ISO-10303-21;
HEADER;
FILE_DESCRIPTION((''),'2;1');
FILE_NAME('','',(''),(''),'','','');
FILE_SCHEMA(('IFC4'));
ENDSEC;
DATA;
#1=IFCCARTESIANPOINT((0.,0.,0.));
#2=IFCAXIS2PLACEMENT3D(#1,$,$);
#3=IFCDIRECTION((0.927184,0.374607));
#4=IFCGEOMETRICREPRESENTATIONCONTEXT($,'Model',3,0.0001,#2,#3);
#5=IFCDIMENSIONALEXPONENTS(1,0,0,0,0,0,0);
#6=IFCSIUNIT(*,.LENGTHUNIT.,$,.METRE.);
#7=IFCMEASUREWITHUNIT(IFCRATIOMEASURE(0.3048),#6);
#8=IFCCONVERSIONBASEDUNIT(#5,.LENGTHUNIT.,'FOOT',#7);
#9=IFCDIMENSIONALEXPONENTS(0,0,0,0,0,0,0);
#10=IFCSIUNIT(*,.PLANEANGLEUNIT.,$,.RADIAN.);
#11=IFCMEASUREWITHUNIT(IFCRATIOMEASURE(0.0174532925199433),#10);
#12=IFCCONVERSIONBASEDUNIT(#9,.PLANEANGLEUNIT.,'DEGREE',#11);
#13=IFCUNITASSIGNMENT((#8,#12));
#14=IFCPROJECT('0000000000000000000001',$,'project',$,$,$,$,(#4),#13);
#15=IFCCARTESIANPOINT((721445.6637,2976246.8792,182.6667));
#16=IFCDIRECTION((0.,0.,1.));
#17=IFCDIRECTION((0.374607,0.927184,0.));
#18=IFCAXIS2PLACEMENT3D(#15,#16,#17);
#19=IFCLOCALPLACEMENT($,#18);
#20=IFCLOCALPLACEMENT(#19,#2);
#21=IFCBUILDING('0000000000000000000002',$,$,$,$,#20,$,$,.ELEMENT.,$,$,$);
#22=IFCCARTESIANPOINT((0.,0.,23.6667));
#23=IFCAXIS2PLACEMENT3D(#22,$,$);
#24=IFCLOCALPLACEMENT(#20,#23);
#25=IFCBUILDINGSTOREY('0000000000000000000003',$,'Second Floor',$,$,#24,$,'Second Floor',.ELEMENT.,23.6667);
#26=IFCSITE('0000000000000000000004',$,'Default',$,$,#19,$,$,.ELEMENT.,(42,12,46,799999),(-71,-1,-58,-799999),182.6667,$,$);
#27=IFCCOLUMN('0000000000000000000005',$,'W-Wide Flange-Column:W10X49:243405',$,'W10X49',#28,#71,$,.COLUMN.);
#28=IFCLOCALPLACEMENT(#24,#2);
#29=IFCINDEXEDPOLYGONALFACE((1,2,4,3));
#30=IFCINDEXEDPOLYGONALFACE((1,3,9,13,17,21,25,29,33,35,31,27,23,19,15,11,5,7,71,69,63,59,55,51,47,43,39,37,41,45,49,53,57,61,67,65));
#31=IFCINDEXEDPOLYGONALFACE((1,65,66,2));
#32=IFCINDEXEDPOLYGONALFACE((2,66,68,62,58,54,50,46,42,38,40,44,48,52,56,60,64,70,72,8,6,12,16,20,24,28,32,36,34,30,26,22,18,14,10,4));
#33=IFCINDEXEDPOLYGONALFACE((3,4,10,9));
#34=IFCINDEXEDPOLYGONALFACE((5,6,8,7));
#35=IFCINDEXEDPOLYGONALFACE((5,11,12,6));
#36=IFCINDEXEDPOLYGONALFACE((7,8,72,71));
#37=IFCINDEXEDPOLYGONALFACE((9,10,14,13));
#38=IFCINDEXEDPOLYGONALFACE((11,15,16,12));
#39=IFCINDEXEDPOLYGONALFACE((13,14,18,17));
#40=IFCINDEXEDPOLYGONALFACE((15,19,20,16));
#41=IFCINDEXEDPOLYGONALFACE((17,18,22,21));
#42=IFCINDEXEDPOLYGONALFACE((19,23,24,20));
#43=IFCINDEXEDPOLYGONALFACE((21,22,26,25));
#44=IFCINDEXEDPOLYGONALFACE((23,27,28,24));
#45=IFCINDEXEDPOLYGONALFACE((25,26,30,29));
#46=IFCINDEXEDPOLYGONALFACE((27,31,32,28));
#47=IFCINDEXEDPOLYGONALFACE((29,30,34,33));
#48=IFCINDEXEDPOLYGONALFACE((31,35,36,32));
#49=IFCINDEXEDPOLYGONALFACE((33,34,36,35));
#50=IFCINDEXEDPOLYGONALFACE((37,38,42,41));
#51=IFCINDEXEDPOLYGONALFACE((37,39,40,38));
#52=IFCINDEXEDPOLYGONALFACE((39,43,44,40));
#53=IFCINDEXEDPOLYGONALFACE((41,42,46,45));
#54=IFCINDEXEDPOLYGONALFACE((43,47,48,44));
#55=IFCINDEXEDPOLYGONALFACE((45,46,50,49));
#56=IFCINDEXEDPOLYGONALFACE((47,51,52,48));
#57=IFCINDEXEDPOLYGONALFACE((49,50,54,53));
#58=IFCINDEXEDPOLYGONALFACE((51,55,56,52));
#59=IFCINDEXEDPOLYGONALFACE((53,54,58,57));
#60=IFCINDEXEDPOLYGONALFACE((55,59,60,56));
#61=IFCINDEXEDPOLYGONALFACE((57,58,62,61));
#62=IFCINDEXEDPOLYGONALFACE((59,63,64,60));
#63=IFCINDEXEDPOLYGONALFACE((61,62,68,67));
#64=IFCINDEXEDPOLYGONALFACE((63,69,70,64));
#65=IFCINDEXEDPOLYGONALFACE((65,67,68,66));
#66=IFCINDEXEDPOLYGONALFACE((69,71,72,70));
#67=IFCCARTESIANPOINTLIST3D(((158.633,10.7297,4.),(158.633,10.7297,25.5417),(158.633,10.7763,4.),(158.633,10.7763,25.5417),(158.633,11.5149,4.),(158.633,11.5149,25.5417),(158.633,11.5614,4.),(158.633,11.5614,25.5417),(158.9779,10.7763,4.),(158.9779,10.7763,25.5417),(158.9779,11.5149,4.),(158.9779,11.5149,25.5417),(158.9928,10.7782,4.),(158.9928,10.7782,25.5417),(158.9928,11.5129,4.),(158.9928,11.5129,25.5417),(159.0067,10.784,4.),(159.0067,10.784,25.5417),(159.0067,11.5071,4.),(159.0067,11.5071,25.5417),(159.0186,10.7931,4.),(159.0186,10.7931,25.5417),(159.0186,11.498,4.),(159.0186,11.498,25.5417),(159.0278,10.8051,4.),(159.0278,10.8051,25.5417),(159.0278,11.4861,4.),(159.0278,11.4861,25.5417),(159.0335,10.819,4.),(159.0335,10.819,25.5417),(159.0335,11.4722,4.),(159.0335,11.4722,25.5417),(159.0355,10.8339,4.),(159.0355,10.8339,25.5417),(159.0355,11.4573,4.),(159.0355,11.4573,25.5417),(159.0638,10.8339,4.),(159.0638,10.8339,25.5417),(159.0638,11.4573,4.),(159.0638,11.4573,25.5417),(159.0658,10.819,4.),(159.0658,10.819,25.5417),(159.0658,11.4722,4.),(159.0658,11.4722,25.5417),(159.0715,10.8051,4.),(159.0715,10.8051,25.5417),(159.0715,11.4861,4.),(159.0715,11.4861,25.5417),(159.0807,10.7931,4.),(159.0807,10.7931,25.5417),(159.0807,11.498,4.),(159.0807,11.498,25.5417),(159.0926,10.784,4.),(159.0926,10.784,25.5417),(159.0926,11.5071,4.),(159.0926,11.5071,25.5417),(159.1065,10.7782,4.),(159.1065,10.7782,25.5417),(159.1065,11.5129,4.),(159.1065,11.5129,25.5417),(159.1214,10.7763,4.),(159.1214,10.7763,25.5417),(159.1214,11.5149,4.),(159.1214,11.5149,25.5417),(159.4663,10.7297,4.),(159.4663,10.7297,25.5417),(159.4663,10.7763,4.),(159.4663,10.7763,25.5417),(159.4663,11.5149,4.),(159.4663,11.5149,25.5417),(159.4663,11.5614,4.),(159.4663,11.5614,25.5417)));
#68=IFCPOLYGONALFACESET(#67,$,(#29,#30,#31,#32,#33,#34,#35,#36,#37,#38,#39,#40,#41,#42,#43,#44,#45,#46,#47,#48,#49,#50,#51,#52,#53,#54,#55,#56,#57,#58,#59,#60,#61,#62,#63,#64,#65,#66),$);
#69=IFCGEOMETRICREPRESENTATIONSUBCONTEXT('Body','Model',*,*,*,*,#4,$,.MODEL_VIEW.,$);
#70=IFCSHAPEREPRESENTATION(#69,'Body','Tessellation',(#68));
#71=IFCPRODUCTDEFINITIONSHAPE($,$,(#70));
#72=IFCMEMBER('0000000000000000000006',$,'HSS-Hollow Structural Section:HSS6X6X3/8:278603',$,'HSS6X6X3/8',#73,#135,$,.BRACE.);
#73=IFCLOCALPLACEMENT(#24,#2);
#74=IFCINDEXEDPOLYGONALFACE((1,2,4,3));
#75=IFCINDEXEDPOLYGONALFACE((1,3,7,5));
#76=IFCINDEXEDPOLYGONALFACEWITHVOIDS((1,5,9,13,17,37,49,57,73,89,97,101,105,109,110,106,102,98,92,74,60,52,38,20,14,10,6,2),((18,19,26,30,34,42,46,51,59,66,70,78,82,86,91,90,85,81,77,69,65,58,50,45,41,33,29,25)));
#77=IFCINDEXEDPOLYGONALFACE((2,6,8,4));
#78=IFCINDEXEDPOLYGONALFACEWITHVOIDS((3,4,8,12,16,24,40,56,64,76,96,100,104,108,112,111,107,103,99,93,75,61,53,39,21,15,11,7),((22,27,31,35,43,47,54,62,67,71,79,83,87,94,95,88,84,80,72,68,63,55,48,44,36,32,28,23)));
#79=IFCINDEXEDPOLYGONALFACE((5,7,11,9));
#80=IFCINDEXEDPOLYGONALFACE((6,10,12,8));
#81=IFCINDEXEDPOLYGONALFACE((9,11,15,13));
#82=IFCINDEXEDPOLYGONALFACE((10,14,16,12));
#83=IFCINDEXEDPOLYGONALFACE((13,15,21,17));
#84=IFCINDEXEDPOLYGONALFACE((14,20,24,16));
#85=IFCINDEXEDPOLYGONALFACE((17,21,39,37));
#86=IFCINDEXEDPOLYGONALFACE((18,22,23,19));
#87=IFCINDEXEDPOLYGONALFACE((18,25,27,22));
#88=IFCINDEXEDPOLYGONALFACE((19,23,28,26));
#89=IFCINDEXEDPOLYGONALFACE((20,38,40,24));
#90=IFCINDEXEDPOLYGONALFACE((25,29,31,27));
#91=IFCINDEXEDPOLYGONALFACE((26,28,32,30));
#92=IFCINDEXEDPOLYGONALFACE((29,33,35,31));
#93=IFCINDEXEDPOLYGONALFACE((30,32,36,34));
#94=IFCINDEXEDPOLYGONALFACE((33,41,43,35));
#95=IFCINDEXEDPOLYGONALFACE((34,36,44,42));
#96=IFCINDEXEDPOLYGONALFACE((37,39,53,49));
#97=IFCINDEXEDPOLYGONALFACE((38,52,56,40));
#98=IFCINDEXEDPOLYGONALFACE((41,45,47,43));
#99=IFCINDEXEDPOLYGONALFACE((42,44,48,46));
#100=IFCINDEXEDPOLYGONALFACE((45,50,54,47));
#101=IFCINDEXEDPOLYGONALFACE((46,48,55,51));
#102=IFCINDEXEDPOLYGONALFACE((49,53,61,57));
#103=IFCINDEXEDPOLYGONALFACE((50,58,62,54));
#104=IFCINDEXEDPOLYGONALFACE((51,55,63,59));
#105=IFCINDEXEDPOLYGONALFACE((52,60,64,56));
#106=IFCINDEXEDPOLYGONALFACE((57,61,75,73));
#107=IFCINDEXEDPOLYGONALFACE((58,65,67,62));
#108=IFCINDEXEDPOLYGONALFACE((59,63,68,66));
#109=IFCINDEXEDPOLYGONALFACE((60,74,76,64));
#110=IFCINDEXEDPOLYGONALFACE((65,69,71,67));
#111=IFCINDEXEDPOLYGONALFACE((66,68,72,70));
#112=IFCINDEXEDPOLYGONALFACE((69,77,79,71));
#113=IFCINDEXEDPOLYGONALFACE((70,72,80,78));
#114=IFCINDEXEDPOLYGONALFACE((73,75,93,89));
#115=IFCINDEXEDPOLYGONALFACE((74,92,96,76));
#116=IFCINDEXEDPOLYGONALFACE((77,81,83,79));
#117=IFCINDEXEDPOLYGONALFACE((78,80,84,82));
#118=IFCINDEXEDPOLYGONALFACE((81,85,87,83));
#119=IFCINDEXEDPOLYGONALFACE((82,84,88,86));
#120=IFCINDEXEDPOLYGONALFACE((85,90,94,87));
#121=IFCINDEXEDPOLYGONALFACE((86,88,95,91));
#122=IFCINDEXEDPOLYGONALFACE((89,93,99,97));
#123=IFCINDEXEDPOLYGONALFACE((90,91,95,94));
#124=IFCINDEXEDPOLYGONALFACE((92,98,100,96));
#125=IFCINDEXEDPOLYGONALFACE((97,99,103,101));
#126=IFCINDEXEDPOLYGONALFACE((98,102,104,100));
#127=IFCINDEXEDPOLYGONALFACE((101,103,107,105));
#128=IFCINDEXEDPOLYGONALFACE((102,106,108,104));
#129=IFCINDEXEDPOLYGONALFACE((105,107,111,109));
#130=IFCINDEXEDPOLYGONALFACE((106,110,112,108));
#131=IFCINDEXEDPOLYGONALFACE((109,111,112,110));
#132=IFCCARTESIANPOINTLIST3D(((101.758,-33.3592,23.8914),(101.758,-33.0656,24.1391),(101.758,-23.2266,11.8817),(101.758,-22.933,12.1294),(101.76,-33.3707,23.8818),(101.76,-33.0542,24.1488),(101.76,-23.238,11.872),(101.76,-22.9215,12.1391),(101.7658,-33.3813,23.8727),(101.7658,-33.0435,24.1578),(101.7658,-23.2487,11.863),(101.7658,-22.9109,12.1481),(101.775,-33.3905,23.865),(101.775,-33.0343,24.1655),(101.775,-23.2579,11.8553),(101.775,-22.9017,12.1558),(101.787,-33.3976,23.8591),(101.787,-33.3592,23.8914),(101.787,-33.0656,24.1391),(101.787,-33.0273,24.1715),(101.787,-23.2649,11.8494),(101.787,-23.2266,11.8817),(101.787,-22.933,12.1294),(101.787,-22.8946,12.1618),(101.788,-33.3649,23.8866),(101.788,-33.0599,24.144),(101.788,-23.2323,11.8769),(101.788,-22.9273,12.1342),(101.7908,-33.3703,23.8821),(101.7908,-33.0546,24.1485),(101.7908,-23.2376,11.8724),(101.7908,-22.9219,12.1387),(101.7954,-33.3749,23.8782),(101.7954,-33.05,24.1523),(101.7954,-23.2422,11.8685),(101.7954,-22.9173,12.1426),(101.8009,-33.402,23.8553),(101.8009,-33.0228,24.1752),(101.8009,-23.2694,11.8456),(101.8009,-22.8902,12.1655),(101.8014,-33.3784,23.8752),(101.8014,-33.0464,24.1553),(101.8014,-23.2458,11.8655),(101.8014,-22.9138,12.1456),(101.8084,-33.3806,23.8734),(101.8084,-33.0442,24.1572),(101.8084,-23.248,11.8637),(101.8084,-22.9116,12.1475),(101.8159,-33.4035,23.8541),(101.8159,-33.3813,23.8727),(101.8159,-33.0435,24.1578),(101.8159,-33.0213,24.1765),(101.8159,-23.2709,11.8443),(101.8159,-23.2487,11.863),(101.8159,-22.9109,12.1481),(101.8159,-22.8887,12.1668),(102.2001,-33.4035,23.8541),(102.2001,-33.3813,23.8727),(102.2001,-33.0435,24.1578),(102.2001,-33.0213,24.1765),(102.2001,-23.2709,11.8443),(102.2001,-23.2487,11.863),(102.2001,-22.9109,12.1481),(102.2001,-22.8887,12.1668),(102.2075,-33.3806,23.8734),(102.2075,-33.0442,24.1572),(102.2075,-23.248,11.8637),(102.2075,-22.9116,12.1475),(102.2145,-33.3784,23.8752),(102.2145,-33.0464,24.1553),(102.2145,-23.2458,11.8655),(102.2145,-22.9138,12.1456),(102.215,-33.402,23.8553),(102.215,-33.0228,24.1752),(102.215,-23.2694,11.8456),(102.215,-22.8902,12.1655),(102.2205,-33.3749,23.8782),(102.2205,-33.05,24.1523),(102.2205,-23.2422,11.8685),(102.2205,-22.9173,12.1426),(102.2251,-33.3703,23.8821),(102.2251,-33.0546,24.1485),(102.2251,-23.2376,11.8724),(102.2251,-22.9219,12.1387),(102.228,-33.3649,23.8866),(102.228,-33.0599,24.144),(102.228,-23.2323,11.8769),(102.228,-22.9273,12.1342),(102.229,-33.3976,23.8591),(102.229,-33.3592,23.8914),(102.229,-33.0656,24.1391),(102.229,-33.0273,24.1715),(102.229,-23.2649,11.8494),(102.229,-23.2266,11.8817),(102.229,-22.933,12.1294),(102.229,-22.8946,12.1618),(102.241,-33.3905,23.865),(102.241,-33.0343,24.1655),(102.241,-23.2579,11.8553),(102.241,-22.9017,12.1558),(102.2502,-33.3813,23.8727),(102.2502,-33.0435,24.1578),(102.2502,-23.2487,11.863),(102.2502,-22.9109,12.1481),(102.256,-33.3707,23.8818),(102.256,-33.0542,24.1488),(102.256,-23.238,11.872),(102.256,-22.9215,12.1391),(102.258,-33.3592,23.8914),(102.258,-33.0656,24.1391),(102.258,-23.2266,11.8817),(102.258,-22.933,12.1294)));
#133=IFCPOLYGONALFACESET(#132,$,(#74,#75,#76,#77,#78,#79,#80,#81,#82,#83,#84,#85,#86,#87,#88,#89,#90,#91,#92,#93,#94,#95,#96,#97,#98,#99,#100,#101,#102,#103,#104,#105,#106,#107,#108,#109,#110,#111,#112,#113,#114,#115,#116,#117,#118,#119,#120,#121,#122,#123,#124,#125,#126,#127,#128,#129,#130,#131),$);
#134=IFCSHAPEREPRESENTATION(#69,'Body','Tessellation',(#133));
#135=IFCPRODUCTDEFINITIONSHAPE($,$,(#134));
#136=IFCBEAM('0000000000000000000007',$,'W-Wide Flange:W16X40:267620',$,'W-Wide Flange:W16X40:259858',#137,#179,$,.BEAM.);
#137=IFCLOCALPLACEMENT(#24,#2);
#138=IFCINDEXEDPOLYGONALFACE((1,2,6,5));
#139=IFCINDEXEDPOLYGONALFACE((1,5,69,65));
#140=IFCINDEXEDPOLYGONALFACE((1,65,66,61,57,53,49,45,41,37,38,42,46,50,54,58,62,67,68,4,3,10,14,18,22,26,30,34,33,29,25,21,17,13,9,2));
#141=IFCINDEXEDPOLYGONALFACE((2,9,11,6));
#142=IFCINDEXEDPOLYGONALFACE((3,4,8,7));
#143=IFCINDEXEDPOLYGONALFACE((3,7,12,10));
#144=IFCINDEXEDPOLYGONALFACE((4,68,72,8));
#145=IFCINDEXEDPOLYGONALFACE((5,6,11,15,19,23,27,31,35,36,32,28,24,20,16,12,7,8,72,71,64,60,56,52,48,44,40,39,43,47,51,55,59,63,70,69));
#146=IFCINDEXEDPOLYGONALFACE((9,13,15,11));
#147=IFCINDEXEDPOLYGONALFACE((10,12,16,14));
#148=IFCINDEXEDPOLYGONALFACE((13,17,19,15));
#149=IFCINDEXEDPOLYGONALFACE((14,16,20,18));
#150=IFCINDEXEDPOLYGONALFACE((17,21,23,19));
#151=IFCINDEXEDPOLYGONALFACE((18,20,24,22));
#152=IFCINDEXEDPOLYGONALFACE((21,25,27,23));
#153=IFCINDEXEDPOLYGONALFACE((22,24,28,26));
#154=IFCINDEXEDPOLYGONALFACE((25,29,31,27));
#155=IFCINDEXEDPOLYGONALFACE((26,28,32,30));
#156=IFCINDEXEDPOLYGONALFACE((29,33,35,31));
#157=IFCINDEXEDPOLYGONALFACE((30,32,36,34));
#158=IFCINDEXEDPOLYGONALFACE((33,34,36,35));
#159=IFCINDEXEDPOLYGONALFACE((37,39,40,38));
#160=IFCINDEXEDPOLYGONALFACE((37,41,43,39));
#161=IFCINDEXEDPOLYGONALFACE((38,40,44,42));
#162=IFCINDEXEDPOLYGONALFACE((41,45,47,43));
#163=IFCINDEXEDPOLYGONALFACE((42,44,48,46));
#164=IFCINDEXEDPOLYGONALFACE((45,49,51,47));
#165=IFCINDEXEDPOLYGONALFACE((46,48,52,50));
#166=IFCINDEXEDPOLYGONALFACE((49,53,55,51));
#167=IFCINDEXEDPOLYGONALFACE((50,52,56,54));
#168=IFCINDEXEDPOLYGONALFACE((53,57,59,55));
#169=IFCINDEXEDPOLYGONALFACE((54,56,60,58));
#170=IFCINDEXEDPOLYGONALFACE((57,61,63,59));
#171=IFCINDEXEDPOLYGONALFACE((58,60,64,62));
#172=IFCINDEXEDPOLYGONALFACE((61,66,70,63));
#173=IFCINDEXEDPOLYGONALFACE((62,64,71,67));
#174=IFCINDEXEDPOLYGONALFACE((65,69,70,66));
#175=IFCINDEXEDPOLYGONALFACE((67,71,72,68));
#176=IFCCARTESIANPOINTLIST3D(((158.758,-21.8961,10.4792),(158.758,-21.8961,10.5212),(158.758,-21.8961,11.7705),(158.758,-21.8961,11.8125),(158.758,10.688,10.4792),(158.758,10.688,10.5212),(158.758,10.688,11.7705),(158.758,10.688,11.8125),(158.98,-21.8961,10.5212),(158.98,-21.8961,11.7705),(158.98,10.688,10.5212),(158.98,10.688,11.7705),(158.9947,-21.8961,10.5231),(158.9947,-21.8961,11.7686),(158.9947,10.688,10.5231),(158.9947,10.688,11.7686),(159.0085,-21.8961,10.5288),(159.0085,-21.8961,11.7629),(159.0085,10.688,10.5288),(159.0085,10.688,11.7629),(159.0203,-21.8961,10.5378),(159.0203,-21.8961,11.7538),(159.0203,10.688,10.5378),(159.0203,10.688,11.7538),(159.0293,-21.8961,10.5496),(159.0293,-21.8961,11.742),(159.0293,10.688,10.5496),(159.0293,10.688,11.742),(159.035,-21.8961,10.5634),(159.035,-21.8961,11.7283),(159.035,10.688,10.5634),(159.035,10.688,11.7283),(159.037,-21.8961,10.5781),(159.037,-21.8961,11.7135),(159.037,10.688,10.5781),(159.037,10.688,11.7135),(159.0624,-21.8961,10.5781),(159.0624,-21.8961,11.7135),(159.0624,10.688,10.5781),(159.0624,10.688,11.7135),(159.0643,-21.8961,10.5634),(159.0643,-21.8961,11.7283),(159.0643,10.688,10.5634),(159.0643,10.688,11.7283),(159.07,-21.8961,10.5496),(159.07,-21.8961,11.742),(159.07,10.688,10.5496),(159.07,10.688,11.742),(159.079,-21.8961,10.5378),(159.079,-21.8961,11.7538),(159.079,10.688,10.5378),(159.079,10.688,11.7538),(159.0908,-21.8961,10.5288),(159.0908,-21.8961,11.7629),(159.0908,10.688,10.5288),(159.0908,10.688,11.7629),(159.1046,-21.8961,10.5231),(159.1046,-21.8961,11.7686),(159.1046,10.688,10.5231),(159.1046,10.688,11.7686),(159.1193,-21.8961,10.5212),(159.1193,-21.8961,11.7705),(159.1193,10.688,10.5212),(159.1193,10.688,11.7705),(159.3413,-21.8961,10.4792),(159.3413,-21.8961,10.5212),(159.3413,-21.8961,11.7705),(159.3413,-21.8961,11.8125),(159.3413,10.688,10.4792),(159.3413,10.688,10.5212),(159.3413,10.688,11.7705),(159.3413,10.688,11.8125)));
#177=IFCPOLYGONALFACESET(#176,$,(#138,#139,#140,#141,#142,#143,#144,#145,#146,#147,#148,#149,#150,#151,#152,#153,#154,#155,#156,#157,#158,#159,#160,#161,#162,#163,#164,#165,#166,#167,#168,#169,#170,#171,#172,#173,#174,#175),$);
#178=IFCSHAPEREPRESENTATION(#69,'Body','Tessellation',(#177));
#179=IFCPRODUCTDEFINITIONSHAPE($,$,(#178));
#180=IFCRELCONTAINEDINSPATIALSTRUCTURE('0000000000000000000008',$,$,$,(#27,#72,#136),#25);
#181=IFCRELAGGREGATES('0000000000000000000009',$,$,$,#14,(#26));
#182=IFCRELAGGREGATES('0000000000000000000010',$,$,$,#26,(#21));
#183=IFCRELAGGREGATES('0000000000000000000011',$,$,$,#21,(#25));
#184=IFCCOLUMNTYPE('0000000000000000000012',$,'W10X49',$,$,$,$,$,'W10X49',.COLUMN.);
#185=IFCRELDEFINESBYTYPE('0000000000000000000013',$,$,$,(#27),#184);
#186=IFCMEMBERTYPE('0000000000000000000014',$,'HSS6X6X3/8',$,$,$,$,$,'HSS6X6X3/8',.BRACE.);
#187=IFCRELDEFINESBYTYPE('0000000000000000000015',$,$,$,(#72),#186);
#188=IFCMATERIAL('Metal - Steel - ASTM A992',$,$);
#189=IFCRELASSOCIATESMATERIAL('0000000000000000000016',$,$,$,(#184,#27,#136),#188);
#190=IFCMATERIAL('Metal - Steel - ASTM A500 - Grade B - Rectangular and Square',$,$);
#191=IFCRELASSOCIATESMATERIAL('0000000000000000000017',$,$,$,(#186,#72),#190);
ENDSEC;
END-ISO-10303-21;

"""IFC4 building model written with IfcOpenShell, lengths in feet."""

from ifc_helpers import new_model, entity, si_unit, converted_unit, direction, frame, frame_2d, origin, place, context, subcontext, project, spatial, polyline, circle_curve, parameter, trimmed, segment, composite_curve, i_section, outline, extrude, source, transform, mapped, material, type_object, type_shapes, element, save


model = new_model("IFC4")

# Units and contexts
model_context = context("Model", 3, precision=0.0001, world=origin(), true_north=direction((0.927184, 0.374607)))
body_context = subcontext(model_context, "Body", "Model", "MODEL_VIEW")
ifc_project = project(units=[converted_unit("LENGTHUNIT", "FOOT", entity("IfcRatioMeasure", 0.3048), si_unit("LENGTHUNIT", "METRE"), dimensions=[1, 0, 0, 0, 0, 0, 0]), converted_unit("PLANEANGLEUNIT", "DEGREE", entity("IfcRatioMeasure", 0.0174532925199433), si_unit("PLANEANGLEUNIT", "RADIAN"), dimensions=[0, 0, 0, 0, 0, 0, 0])], contexts=[model_context])

# Site, building, storey
site_placement = place(None, frame((721445.6637, 2976246.8792, 182.6667), z_axis=(0.0, 0.0, 1.0), x_axis=(0.374607, 0.927184, 0.0)))
site = spatial("IfcSite", under=ifc_project, at=site_placement, Name="Default", CompositionType="ELEMENT", RefLatitude=(42, 12, 46, 799999), RefLongitude=(-71, -1, -58, -799999), RefElevation=182.6667)
building_placement = place(site_placement, origin())
building = spatial("IfcBuilding", under=site, at=building_placement, CompositionType="ELEMENT")
storey_placement = place(building_placement, frame((0.0, 0.0, 23.6667)))
storey = spatial("IfcBuildingStorey", under=building, at=storey_placement, Name="Second Floor", LongName="Second Floor", CompositionType="ELEMENT", Elevation=23.6667)

# Column
ifc_material_1 = material(Name="Metal - Steel - ASTM A992")
column_type = type_object("IfcColumnType", Name="W10X49", ElementType="W10X49", PredefinedType="COLUMN", material=ifc_material_1)
shared_shape_1 = source(origin(), body_context, "Body", "SweptSolid", [
    extrude(i_section(OverallWidth=0.8333, OverallDepth=0.8317, WebThickness=0.0283, FlangeThickness=0.0465, FilletRadius=0.0576, at=frame_2d((0.0, 0.0), x_axis=(0.0, 1.0))), frame((0.0, 0.0, 27.6667), z_axis=(0.0, 0.0, 1.0), x_axis=(0.0, -1.0, 0.0)), (0.0, 0.0, 1.0), 21.5417),
])
type_shapes(column_type, [shared_shape_1])
for number, where, z_axis, x_axis, name in (
    (1, (159.0497, 11.1456, -23.6667), (0.0, 0.0, 1.0), (-1.0, 0.0, 0.0), "W-Wide Flange-Column:W10X49:243405"),
):
    element("IfcColumn", number, at=place(storey_placement, frame(where, z_axis=z_axis, x_axis=x_axis)), inside=storey, type_object=column_type, material=ifc_material_1, Name=name, ObjectType="W10X49", PredefinedType="COLUMN", context=body_context, shape_type="MappedRepresentation", body=[
        mapped(shared_shape_1, transform((0.0, 0.0, 0.0), scale=1.0)),
    ])

# Member
ifc_material_2 = material(Name="Metal - Steel - ASTM A500 - Grade B - Rectangular and Square")
member_type_1 = type_object("IfcMemberType", Name="HSS6X6X3/8", ElementType="HSS6X6X3/8", PredefinedType="BRACE", material=ifc_material_2)
shared_shape_2 = source(origin(), body_context, "Body", "SweptSolid", [
    extrude(outline(composite_curve([segment(trimmed(circle_curve(frame_2d((-0.1921, -0.1921), x_axis=(1.0, 0.0)), 0.0579), [parameter(180.0)], [parameter(270.0)], True, "PARAMETER"), True, "CONTINUOUS"), segment(polyline([(-0.1921, -0.25), (0.1921, -0.25)]), True, "CONTINUOUS"), segment(trimmed(circle_curve(frame_2d((0.1921, -0.1921), x_axis=(1.0, 0.0)), 0.0579), [parameter(270.0)], [parameter(0.0)], True, "PARAMETER"), True, "CONTINUOUS"), segment(polyline([(0.25, -0.1921), (0.25, 0.1921)]), True, "CONTINUOUS"), segment(trimmed(circle_curve(frame_2d((0.1921, 0.1921), x_axis=(1.0, 0.0)), 0.0579), [parameter(360.0)], [parameter(90.0)], True, "PARAMETER"), True, "CONTINUOUS"), segment(polyline([(0.1921, 0.25), (-0.1921, 0.25)]), True, "CONTINUOUS"), segment(trimmed(circle_curve(frame_2d((-0.1921, 0.1921), x_axis=(1.0, 0.0)), 0.0579), [parameter(90.0)], [parameter(180.0)], True, "PARAMETER"), True, "CONTINUOUS"), segment(polyline([(-0.25, 0.1921), (-0.25, -0.1921)]), True, "CONTINUOUS")], self_intersect=False), holes=[composite_curve([segment(polyline([(0.1921, -0.221), (-0.1921, -0.221)]), True, "CONTINUOUS"), segment(trimmed(circle_curve(frame_2d((-0.1921, -0.1921), x_axis=(1.0, 0.0)), 0.029), [parameter(180.0)], [parameter(270.0)], True, "PARAMETER"), False, "CONTINUOUS"), segment(polyline([(-0.221, -0.1921), (-0.221, 0.1921)]), True, "CONTINUOUS"), segment(trimmed(circle_curve(frame_2d((-0.1921, 0.1921), x_axis=(1.0, 0.0)), 0.029), [parameter(90.0)], [parameter(180.0)], True, "PARAMETER"), False, "CONTINUOUS"), segment(polyline([(-0.1921, 0.221), (0.1921, 0.221)]), True, "CONTINUOUS"), segment(trimmed(circle_curve(frame_2d((0.1921, 0.1921), x_axis=(1.0, 0.0)), 0.029), [parameter(0.0)], [parameter(90.0)], True, "PARAMETER"), False, "CONTINUOUS"), segment(polyline([(0.221, 0.1921), (0.221, -0.1921)]), True, "CONTINUOUS"), segment(trimmed(circle_curve(frame_2d((0.1921, -0.1921), x_axis=(1.0, 0.0)), 0.029), [parameter(270.0)], [parameter(0.0)], True, "PARAMETER"), False, "CONTINUOUS")], self_intersect=False)]), frame((-7.8566, 0.0, 0.0), z_axis=(1.0, 0.0, 0.0), x_axis=(0.0, -1.0, 0.0)), (0.0, 0.0, 1.0), 15.7132),
])
type_shapes(member_type_1, [shared_shape_2])
member_1_placement = place(storey_placement, frame((102.008, -28.1461, 18.0104), z_axis=(0.0, 0.764309, 0.64485), x_axis=(0.0, -0.64485, 0.764309)))
element("IfcMember", 2, at=member_1_placement, inside=storey, type_object=member_type_1, material=ifc_material_2, Name="HSS-Hollow Structural Section:HSS6X6X3/8:278603", ObjectType="HSS6X6X3/8", PredefinedType="BRACE", context=body_context, shape_type="MappedRepresentation", body=[
    mapped(shared_shape_2, transform((0.0, 0.0, 0.0), scale=1.0)),
])

# Beam
beam_1_placement = place(storey_placement, frame((159.0497, 11.1456, 11.8125), z_axis=(0.0, 0.0, 1.0), x_axis=(0.0, -1.0, 0.0)))
element("IfcBeam", 3, at=beam_1_placement, inside=storey, material=ifc_material_1, Name="W-Wide Flange:W16X40:267620", ObjectType="W-Wide Flange:W16X40:259858", PredefinedType="BEAM", context=body_context, shape_type="SweptSolid", body=[
    extrude(i_section(OverallWidth=0.5833, OverallDepth=1.3333, WebThickness=0.0254, FlangeThickness=0.042, FilletRadius=0.057, at=frame_2d((0.0, 0.0), x_axis=(0.0, 1.0))), frame((0.4575, 0.0, -0.6667), z_axis=(1.0, 0.0, 0.0), x_axis=(0.0, 0.0, -1.0)), (0.0, 0.0, 1.0), 32.5841),
])

save(model, "model.ifc")
